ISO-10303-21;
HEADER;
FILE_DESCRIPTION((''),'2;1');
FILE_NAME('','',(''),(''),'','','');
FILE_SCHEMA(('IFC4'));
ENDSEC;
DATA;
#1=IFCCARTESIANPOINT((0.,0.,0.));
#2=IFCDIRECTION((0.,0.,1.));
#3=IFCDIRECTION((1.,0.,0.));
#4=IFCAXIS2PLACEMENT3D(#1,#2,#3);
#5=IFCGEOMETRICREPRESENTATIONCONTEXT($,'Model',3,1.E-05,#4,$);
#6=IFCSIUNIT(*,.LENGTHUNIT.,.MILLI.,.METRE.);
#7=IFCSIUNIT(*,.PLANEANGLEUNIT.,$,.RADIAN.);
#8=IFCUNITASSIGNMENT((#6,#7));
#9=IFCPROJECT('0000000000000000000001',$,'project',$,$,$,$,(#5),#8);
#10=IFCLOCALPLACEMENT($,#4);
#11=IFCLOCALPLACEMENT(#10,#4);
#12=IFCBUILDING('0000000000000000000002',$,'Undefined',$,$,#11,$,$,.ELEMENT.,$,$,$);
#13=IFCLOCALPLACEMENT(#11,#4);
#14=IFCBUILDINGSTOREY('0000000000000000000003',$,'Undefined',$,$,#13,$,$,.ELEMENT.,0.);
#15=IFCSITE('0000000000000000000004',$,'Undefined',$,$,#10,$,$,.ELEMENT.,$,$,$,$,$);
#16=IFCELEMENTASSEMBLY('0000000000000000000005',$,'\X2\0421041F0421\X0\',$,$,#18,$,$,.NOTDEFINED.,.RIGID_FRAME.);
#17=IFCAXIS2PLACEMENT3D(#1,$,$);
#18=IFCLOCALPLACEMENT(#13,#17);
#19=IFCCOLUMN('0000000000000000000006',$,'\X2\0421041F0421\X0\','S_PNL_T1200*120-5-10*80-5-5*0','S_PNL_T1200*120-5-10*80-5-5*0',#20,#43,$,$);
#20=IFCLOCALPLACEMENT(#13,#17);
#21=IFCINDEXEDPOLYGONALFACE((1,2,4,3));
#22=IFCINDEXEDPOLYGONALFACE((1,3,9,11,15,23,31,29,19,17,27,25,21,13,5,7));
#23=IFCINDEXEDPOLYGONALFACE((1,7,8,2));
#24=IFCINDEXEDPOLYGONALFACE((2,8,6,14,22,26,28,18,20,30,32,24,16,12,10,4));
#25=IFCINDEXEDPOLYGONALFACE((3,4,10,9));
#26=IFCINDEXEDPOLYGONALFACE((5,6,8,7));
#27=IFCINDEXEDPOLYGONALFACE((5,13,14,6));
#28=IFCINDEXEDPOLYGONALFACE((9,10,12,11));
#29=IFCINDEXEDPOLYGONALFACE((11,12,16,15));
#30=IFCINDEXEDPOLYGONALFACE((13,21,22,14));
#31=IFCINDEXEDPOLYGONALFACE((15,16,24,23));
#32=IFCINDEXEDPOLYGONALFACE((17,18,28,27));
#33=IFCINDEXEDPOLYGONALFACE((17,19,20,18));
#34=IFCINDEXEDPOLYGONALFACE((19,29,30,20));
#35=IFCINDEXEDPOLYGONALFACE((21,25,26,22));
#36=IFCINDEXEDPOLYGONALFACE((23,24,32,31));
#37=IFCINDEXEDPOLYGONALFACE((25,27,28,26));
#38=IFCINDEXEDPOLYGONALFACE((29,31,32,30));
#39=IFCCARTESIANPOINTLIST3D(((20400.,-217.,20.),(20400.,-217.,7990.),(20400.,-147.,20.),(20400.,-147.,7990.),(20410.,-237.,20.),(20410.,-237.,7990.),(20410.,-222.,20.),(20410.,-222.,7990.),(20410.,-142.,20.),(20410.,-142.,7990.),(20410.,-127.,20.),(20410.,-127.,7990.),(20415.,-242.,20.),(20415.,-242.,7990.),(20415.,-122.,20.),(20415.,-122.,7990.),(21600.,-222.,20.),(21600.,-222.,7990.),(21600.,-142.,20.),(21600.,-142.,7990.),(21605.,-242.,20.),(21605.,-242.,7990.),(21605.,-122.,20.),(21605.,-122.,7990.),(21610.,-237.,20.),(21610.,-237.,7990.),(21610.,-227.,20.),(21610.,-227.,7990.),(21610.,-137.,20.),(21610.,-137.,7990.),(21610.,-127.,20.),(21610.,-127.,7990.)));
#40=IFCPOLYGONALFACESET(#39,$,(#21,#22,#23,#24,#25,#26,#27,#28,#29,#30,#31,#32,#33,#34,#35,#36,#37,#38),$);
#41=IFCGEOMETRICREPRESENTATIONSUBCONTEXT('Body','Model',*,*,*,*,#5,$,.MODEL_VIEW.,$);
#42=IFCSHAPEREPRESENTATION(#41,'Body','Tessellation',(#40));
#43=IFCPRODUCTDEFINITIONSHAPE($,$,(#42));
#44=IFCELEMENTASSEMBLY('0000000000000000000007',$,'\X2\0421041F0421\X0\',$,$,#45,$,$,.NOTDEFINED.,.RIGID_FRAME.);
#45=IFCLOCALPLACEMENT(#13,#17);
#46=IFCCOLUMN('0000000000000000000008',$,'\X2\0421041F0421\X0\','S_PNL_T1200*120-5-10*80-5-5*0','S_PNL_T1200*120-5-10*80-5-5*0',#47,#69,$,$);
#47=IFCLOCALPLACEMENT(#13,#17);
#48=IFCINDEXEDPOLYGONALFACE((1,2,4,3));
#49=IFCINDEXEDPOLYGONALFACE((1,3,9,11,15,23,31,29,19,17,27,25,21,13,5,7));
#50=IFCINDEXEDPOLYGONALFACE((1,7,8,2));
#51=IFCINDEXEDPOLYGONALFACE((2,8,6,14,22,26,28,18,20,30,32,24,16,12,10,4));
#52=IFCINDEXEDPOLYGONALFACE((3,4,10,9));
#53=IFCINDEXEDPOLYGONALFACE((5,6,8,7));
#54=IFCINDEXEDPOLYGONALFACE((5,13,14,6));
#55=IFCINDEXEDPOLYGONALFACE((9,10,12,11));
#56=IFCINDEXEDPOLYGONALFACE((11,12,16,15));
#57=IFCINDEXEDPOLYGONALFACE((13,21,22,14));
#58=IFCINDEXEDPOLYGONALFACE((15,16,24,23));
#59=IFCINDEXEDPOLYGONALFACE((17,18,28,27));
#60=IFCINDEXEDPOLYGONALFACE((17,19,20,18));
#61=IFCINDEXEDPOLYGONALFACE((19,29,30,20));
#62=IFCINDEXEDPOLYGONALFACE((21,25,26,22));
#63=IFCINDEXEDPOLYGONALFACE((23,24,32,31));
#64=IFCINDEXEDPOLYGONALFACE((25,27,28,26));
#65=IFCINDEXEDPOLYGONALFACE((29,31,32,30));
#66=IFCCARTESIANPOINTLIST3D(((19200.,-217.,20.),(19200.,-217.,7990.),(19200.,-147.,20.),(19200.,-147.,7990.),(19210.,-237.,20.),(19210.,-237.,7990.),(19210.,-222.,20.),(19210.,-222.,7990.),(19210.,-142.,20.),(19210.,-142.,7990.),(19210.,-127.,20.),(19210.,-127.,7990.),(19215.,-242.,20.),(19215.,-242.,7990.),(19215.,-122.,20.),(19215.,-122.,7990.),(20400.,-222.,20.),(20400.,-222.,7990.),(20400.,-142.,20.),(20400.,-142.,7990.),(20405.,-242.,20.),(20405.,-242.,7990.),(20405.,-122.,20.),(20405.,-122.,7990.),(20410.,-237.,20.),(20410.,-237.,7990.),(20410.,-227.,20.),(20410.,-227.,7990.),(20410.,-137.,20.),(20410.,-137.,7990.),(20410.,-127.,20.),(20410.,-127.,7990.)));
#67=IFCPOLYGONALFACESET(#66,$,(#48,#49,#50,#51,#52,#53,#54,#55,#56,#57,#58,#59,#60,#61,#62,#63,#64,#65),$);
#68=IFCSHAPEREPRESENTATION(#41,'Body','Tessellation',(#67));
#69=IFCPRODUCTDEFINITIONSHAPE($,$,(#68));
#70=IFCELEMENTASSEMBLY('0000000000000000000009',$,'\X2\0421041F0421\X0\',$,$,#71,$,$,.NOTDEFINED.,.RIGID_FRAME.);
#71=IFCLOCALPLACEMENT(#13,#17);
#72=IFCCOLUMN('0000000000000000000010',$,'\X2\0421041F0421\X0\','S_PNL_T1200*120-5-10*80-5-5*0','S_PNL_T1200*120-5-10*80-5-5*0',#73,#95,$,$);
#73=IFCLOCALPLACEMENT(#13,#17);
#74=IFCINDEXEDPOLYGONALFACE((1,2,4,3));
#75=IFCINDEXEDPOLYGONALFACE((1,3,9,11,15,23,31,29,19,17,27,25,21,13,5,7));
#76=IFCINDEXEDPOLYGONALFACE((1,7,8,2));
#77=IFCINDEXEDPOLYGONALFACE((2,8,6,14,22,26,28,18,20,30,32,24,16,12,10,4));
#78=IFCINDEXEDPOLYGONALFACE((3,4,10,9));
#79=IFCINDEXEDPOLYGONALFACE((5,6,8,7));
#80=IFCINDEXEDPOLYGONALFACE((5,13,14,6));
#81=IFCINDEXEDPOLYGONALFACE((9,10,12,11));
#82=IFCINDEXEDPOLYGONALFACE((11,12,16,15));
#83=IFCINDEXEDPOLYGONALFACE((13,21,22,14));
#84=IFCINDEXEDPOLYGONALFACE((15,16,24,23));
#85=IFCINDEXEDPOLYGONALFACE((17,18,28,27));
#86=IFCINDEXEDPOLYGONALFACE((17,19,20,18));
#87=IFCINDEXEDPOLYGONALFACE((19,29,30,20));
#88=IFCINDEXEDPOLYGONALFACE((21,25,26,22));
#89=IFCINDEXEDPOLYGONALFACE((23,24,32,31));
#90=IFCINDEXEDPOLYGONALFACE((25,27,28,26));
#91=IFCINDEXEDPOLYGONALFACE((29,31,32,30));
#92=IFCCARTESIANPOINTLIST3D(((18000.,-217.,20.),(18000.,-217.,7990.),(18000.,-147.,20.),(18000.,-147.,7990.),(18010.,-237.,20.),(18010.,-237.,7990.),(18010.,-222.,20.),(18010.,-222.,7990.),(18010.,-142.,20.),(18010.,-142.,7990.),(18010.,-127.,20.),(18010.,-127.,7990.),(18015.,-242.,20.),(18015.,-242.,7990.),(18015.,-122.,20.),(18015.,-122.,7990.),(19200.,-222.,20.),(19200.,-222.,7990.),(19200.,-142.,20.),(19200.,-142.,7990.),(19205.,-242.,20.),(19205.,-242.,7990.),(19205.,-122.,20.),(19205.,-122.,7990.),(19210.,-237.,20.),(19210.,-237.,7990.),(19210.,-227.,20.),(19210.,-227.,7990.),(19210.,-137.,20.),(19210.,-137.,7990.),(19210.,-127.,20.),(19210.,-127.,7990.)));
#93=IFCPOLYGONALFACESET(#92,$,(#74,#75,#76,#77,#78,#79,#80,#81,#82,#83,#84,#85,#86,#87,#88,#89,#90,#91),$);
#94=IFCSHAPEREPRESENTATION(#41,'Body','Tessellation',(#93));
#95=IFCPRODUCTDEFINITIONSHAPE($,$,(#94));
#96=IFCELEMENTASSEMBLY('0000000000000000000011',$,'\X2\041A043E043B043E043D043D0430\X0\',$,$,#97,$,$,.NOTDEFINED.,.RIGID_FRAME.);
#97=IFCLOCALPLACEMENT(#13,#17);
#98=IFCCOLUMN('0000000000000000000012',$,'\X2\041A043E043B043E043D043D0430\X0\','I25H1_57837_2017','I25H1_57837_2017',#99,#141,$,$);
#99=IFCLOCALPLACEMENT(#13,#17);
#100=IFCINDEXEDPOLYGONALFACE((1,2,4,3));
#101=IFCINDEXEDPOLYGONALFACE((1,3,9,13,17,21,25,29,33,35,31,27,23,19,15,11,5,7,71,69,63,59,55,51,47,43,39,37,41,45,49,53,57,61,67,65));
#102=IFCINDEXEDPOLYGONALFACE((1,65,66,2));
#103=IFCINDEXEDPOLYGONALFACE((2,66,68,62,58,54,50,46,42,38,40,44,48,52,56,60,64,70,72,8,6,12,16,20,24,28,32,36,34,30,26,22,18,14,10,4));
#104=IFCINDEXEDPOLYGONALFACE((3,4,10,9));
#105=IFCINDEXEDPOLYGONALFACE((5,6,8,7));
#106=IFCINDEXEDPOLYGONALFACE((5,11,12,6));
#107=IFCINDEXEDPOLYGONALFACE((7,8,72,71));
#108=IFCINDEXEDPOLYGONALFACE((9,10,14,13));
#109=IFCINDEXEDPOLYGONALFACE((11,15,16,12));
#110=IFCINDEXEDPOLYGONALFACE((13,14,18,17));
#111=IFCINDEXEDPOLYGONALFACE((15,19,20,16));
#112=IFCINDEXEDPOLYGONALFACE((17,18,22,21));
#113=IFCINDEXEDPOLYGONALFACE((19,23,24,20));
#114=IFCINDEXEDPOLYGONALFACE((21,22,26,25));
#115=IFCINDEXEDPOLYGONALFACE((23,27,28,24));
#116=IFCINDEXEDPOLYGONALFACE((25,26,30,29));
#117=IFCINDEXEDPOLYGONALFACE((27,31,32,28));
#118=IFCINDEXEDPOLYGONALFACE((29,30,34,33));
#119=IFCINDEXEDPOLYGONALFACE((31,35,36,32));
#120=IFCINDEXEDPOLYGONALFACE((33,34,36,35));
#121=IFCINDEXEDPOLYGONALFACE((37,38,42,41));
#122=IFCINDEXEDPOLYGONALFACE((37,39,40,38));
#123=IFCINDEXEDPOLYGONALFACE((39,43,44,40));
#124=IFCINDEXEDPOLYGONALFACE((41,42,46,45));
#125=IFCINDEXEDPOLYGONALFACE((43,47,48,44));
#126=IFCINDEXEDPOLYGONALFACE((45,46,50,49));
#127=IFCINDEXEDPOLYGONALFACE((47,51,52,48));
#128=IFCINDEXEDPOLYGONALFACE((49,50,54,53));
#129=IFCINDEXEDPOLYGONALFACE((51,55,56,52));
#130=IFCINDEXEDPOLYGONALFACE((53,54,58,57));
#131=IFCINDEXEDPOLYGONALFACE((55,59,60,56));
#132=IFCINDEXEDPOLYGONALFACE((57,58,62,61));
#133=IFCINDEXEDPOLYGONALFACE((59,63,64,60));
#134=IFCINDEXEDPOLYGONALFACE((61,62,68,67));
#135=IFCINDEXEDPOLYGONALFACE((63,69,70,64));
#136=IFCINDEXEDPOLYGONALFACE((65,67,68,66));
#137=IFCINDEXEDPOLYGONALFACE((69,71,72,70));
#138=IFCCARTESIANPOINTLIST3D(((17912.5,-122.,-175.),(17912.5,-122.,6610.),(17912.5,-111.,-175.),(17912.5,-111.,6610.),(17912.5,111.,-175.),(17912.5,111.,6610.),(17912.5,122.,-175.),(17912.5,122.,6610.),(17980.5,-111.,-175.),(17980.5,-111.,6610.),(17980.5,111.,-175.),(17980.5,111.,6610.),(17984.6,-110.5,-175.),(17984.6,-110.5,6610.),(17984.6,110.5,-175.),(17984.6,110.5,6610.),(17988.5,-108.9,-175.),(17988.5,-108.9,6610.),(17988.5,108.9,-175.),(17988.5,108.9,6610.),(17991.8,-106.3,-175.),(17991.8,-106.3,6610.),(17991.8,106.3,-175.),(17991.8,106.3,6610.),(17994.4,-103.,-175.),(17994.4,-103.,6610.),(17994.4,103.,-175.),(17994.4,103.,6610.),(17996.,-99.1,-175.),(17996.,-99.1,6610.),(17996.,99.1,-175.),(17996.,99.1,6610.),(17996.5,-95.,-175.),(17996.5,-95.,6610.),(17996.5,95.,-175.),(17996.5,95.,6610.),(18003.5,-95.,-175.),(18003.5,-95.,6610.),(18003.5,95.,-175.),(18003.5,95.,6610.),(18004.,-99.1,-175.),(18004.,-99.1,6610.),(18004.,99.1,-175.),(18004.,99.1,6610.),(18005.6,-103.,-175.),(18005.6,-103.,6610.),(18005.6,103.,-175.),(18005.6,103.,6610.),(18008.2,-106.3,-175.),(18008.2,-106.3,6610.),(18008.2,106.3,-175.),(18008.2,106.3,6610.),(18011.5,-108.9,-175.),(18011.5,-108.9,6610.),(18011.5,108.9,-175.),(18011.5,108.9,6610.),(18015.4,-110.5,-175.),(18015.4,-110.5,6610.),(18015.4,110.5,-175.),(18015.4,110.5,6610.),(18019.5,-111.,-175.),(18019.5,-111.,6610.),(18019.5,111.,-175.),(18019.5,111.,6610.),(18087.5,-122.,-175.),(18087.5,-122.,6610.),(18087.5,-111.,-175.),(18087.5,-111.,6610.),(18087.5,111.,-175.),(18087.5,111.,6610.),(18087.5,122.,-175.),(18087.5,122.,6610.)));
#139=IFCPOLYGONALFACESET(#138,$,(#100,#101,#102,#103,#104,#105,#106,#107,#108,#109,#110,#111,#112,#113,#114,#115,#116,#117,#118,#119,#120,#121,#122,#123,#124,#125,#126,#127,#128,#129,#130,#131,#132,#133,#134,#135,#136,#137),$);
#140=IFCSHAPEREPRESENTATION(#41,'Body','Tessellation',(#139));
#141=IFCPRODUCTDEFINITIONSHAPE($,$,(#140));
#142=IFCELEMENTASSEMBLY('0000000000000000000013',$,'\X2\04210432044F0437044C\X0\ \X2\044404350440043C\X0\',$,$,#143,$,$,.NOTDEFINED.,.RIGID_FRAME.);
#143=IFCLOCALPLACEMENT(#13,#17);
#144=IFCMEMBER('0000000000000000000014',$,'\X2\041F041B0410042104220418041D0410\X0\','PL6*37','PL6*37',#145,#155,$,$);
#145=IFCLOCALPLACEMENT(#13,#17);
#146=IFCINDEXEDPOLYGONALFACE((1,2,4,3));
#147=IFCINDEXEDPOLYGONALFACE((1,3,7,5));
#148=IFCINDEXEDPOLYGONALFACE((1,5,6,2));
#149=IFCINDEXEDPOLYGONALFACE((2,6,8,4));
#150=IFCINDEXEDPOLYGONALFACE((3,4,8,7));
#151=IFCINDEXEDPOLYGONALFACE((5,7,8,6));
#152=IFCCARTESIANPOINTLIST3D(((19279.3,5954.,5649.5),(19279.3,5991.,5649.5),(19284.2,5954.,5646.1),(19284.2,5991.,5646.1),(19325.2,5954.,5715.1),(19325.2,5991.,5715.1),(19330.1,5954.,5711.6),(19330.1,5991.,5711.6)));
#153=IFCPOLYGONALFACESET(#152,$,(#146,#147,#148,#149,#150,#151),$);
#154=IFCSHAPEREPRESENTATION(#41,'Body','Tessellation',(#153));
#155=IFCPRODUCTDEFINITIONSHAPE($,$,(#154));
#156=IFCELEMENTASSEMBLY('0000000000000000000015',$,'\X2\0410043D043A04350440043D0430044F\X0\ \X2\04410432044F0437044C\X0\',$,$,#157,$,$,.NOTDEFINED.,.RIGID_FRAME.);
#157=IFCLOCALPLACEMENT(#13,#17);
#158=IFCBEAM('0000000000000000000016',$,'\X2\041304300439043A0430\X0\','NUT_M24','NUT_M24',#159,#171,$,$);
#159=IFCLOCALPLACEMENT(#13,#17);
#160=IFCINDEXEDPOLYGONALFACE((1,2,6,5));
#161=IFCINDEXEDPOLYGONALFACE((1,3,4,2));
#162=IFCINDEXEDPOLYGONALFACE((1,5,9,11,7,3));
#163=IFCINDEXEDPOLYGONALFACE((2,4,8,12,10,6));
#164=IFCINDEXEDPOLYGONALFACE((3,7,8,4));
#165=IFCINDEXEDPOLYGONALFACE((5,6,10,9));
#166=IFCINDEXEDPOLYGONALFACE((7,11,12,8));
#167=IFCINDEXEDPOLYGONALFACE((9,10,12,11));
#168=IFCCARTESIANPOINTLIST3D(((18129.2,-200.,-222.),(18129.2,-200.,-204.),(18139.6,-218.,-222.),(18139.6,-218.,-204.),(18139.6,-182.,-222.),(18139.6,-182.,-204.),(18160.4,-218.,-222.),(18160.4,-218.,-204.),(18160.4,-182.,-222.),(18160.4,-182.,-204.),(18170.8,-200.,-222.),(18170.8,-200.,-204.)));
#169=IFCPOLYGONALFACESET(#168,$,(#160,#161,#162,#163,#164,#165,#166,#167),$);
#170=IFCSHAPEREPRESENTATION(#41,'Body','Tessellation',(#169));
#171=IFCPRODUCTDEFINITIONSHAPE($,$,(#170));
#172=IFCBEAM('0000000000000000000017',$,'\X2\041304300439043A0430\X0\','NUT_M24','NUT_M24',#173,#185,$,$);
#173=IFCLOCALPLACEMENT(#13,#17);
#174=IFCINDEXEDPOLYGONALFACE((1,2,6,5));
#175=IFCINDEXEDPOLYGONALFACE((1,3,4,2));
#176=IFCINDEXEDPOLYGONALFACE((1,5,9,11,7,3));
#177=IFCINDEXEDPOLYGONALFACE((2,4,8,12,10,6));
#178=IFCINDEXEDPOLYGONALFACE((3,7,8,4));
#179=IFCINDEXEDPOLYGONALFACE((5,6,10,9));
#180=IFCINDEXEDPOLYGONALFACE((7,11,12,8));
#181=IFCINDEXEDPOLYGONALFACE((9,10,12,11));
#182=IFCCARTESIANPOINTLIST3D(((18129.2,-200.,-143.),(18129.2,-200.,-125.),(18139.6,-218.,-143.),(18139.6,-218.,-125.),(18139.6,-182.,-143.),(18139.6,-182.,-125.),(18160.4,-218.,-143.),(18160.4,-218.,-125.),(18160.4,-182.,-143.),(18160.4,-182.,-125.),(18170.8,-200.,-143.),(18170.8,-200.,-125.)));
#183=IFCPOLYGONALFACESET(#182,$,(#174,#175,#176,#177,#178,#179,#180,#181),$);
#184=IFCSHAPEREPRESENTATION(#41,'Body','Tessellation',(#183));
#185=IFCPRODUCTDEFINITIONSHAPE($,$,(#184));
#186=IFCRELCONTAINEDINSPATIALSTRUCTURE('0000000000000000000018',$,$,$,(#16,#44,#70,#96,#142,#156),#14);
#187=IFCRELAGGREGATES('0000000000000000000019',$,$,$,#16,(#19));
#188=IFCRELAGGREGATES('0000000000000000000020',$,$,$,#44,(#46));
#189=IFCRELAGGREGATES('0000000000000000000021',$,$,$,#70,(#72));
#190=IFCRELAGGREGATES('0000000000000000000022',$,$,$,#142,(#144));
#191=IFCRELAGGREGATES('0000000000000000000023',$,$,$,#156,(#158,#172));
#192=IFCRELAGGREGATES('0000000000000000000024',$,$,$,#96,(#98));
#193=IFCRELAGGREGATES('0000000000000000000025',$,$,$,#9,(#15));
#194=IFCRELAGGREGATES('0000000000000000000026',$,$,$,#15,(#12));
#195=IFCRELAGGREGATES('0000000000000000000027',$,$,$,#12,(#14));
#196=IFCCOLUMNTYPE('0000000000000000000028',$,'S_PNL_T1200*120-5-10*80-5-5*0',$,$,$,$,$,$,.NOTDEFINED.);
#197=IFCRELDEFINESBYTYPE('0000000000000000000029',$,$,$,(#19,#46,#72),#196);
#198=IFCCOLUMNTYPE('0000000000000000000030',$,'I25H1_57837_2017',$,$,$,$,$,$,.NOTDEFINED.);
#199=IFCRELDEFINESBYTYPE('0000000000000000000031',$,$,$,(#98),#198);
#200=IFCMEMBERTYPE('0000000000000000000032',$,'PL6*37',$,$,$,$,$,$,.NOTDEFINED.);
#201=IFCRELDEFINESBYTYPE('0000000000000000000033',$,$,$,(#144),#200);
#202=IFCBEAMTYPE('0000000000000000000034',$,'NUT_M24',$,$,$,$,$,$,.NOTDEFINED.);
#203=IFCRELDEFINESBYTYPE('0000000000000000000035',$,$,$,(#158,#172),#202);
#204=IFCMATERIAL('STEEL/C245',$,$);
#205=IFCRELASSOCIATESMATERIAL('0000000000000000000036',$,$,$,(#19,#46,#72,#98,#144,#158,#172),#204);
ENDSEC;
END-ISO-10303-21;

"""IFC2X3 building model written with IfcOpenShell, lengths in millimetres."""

from ifc_helpers import new_model, si_unit, frame, origin_with_axes, origin_2d_with_axis, place, context, subcontext, project, spatial, polyline, rectangle, i_section, outline, extrude, clip, halfspace, material, type_object, element, aggregate, save


model = new_model("IFC2X3")

# Units and contexts
model_context = context("Model", 3, precision=1e-05, world=origin_with_axes())
body_context = subcontext(model_context, "Body", "Model", "MODEL_VIEW")
ifc_project = project(units=[si_unit("LENGTHUNIT", "METRE", prefix="MILLI"), si_unit("PLANEANGLEUNIT", "RADIAN")], contexts=[model_context])

# Site, building, storey
site_placement = place(None, origin_with_axes())
site = spatial("IfcSite", under=ifc_project, at=site_placement, Name="Undefined", CompositionType="ELEMENT")
building_placement = place(site_placement, origin_with_axes())
building = spatial("IfcBuilding", under=site, at=building_placement, Name="Undefined", CompositionType="ELEMENT")
storey_placement = place(building_placement, origin_with_axes())
storey = spatial("IfcBuildingStorey", under=building, at=storey_placement, Name="Undefined", CompositionType="ELEMENT", Elevation=0.0)

# Element assemblies, columns
assembly_1_placement = place(storey_placement, origin_with_axes())
assembly_1 = element("IfcElementAssembly", 1, at=assembly_1_placement, inside=storey, Name="СПС", AssemblyPlace="NOTDEFINED", PredefinedType="RIGID_FRAME")
ifc_material_1 = material(Name="STEEL/C245")
column_type_1 = type_object("IfcColumnType", Name="S_PNL_T1200*120-5-10*80-5-5*0", PredefinedType="NOTDEFINED")
column_1_placement = place(assembly_1_placement, frame((21010.0, -182.0, 20.0), z_axis=(0.0, 0.0, 1.0), x_axis=(-1.0, 0.0, 0.0)))
column_1 = element("IfcColumn", 2, at=column_1_placement, type_object=column_type_1, material=ifc_material_1, Name="СПС", Description="S_PNL_T1200*120-5-10*80-5-5*0", ObjectType="S_PNL_T1200*120-5-10*80-5-5*0", context=body_context, shape_type="SweptSolid", body=[
    extrude(outline(polyline([(-40.0, -590.0), (-45.0, -600.0), (-55.0, -600.0), (-60.0, -595.0), (-60.0, 595.0), (-55.0, 600.0), (-40.0, 600.0), (-35.0, 610.0), (35.0, 610.0), (40.0, 600.0), (55.0, 600.0), (60.0, 595.0), (60.0, -595.0), (55.0, -600.0), (45.0, -600.0), (40.0, -590.0), (-40.0, -590.0)])), frame((0.0, 0.0, 7970.0), z_axis=(0.0, 0.0, -1.0), x_axis=(0.0, 1.0, 0.0)), (0.0, 0.0, 1.0), 7970.0),
])
aggregate(assembly_1, [column_1])
assembly_2_placement = place(storey_placement, origin_with_axes())
assembly_2 = element("IfcElementAssembly", 3, at=assembly_2_placement, inside=storey, Name="СПС", AssemblyPlace="NOTDEFINED", PredefinedType="RIGID_FRAME")
column_2_placement = place(assembly_2_placement, frame((19810.0, -182.0, 20.0), z_axis=(0.0, 0.0, 1.0), x_axis=(-1.0, 0.0, 0.0)))
column_2 = element("IfcColumn", 4, at=column_2_placement, type_object=column_type_1, material=ifc_material_1, Name="СПС", Description="S_PNL_T1200*120-5-10*80-5-5*0", ObjectType="S_PNL_T1200*120-5-10*80-5-5*0", context=body_context, shape_type="SweptSolid", body=[
    extrude(outline(polyline([(-40.0, -590.0), (-45.0, -600.0), (-55.0, -600.0), (-60.0, -595.0), (-60.0, 595.0), (-55.0, 600.0), (-40.0, 600.0), (-35.0, 610.0), (35.0, 610.0), (40.0, 600.0), (55.0, 600.0), (60.0, 595.0), (60.0, -595.0), (55.0, -600.0), (45.0, -600.0), (40.0, -590.0), (-40.0, -590.0)])), frame((0.0, 0.0, 7970.0), z_axis=(0.0, 0.0, -1.0), x_axis=(0.0, 1.0, 0.0)), (0.0, 0.0, 1.0), 7970.0),
])
aggregate(assembly_2, [column_2])
assembly_3_placement = place(storey_placement, origin_with_axes())
assembly_3 = element("IfcElementAssembly", 5, at=assembly_3_placement, inside=storey, Name="СПС", AssemblyPlace="NOTDEFINED", PredefinedType="RIGID_FRAME")
column_3_placement = place(assembly_3_placement, frame((18610.0, -182.0, 20.0), z_axis=(0.0, 0.0, 1.0), x_axis=(-1.0, 0.0, 0.0)))
column_3 = element("IfcColumn", 6, at=column_3_placement, type_object=column_type_1, material=ifc_material_1, Name="СПС", Description="S_PNL_T1200*120-5-10*80-5-5*0", ObjectType="S_PNL_T1200*120-5-10*80-5-5*0", context=body_context, shape_type="SweptSolid", body=[
    extrude(outline(polyline([(-40.0, -590.0), (-45.0, -600.0), (-55.0, -600.0), (-60.0, -595.0), (-60.0, 595.0), (-55.0, 600.0), (-40.0, 600.0), (-35.0, 610.0), (35.0, 610.0), (40.0, 600.0), (55.0, 600.0), (60.0, 595.0), (60.0, -595.0), (55.0, -600.0), (45.0, -600.0), (40.0, -590.0), (-40.0, -590.0)])), frame((0.0, 0.0, 7970.0), z_axis=(0.0, 0.0, -1.0), x_axis=(0.0, 1.0, 0.0)), (0.0, 0.0, 1.0), 7970.0),
])
aggregate(assembly_3, [column_3])
assembly_4_placement = place(storey_placement, origin_with_axes())
assembly_4 = element("IfcElementAssembly", 7, at=assembly_4_placement, inside=storey, Name="Колонна", AssemblyPlace="NOTDEFINED", PredefinedType="RIGID_FRAME")
column_type_2 = type_object("IfcColumnType", Name="I25H1_57837_2017", PredefinedType="NOTDEFINED")
column_4_placement = place(assembly_4_placement, frame((18000.0, 0.0, 0.0), z_axis=(0.0, 0.0, 1.0), x_axis=(0.0, 1.0, 0.0)))
column_4 = element("IfcColumn", 8, at=column_4_placement, type_object=column_type_2, material=ifc_material_1, Name="Колонна", Description="I25H1_57837_2017", ObjectType="I25H1_57837_2017", context=body_context, shape_type="Clipping", body=[
    clip(extrude(i_section(OverallWidth=175.0, OverallDepth=244.0, WebThickness=7.0, FlangeThickness=11.0, FilletRadius=16.0, at=origin_2d_with_axis()), frame((0.0, 0.0, 6610.0), z_axis=(0.0, 0.0, -1.0), x_axis=(0.0, 1.0, 0.0)), (0.0, 0.0, 1.0), 6785.0), halfspace(frame((-122.0, 0.0, -175.0), z_axis=(0.0, 0.0, 1.0), x_axis=(0.0, 1.0, 0.0)), True)),
])

# Element assembly, member
assembly_5_placement = place(storey_placement, origin_with_axes())
assembly_5 = element("IfcElementAssembly", 9, at=assembly_5_placement, inside=storey, Name="Связь ферм", AssemblyPlace="NOTDEFINED", PredefinedType="RIGID_FRAME")
member_type = type_object("IfcMemberType", Name="PL6*37", PredefinedType="NOTDEFINED")
member_placement = place(assembly_5_placement, frame((19281.8, 5972.5, 5647.8), z_axis=(0.0, 1.0, 0.0), x_axis=(0.573078, 0.0, 0.819501)))
member = element("IfcMember", 10, at=member_placement, type_object=member_type, material=ifc_material_1, Name="ПЛАСТИНА", Description="PL6*37", ObjectType="PL6*37", context=body_context, shape_type="SweptSolid", body=[
    extrude(rectangle(XDim=6.0, YDim=37.0, at=origin_2d_with_axis()), frame((80.0, 0.0, 0.0), z_axis=(-1.0, 0.0, 0.0), x_axis=(0.0, -1.0, 0.0)), (0.0, 0.0, 1.0), 80.0),
])
aggregate(assembly_5, [member])

# Element assembly, beams
assembly_6_placement = place(storey_placement, origin_with_axes())
assembly_6 = element("IfcElementAssembly", 11, at=assembly_6_placement, inside=storey, Name="Анкерная связь", AssemblyPlace="NOTDEFINED", PredefinedType="RIGID_FRAME")
beam_type_1 = type_object("IfcBeamType", Name="NUT_M24", PredefinedType="NOTDEFINED")
beam_1_placement = place(assembly_6_placement, frame((18150.0, -200.0, -204.0), z_axis=(0.0, 1.0, 0.0), x_axis=(0.0, 0.0, -1.0)))
beam_1 = element("IfcBeam", 12, at=beam_1_placement, type_object=beam_type_1, material=ifc_material_1, Name="Гайка", Description="NUT_M24", ObjectType="NUT_M24", context=body_context, shape_type="SweptSolid", body=[
    extrude(outline(polyline([(-10.4, 18.0), (10.4, 18.0), (20.8, 0.0), (10.4, -18.0), (-10.4, -18.0), (-20.8, 0.0), (-10.4, 18.0)])), frame((18.0, 0.0, 0.0), z_axis=(-1.0, 0.0, 0.0), x_axis=(0.0, -1.0, 0.0)), (0.0, 0.0, 1.0), 18.0),
])
beam_2_placement = place(assembly_6_placement, frame((18150.0, -200.0, -125.0), z_axis=(0.0, 1.0, 0.0), x_axis=(0.0, 0.0, -1.0)))
beam_2 = element("IfcBeam", 13, at=beam_2_placement, type_object=beam_type_1, material=ifc_material_1, Name="Гайка", Description="NUT_M24", ObjectType="NUT_M24", context=body_context, shape_type="SweptSolid", body=[
    extrude(outline(polyline([(-10.4, 18.0), (10.4, 18.0), (20.8, 0.0), (10.4, -18.0), (-10.4, -18.0), (-20.8, 0.0), (-10.4, 18.0)])), frame((18.0, 0.0, 0.0), z_axis=(-1.0, 0.0, 0.0), x_axis=(0.0, -1.0, 0.0)), (0.0, 0.0, 1.0), 18.0),
])

aggregate(assembly_6, [beam_1, beam_2])
aggregate(assembly_4, [column_4])

save(model, "model.ifc")
